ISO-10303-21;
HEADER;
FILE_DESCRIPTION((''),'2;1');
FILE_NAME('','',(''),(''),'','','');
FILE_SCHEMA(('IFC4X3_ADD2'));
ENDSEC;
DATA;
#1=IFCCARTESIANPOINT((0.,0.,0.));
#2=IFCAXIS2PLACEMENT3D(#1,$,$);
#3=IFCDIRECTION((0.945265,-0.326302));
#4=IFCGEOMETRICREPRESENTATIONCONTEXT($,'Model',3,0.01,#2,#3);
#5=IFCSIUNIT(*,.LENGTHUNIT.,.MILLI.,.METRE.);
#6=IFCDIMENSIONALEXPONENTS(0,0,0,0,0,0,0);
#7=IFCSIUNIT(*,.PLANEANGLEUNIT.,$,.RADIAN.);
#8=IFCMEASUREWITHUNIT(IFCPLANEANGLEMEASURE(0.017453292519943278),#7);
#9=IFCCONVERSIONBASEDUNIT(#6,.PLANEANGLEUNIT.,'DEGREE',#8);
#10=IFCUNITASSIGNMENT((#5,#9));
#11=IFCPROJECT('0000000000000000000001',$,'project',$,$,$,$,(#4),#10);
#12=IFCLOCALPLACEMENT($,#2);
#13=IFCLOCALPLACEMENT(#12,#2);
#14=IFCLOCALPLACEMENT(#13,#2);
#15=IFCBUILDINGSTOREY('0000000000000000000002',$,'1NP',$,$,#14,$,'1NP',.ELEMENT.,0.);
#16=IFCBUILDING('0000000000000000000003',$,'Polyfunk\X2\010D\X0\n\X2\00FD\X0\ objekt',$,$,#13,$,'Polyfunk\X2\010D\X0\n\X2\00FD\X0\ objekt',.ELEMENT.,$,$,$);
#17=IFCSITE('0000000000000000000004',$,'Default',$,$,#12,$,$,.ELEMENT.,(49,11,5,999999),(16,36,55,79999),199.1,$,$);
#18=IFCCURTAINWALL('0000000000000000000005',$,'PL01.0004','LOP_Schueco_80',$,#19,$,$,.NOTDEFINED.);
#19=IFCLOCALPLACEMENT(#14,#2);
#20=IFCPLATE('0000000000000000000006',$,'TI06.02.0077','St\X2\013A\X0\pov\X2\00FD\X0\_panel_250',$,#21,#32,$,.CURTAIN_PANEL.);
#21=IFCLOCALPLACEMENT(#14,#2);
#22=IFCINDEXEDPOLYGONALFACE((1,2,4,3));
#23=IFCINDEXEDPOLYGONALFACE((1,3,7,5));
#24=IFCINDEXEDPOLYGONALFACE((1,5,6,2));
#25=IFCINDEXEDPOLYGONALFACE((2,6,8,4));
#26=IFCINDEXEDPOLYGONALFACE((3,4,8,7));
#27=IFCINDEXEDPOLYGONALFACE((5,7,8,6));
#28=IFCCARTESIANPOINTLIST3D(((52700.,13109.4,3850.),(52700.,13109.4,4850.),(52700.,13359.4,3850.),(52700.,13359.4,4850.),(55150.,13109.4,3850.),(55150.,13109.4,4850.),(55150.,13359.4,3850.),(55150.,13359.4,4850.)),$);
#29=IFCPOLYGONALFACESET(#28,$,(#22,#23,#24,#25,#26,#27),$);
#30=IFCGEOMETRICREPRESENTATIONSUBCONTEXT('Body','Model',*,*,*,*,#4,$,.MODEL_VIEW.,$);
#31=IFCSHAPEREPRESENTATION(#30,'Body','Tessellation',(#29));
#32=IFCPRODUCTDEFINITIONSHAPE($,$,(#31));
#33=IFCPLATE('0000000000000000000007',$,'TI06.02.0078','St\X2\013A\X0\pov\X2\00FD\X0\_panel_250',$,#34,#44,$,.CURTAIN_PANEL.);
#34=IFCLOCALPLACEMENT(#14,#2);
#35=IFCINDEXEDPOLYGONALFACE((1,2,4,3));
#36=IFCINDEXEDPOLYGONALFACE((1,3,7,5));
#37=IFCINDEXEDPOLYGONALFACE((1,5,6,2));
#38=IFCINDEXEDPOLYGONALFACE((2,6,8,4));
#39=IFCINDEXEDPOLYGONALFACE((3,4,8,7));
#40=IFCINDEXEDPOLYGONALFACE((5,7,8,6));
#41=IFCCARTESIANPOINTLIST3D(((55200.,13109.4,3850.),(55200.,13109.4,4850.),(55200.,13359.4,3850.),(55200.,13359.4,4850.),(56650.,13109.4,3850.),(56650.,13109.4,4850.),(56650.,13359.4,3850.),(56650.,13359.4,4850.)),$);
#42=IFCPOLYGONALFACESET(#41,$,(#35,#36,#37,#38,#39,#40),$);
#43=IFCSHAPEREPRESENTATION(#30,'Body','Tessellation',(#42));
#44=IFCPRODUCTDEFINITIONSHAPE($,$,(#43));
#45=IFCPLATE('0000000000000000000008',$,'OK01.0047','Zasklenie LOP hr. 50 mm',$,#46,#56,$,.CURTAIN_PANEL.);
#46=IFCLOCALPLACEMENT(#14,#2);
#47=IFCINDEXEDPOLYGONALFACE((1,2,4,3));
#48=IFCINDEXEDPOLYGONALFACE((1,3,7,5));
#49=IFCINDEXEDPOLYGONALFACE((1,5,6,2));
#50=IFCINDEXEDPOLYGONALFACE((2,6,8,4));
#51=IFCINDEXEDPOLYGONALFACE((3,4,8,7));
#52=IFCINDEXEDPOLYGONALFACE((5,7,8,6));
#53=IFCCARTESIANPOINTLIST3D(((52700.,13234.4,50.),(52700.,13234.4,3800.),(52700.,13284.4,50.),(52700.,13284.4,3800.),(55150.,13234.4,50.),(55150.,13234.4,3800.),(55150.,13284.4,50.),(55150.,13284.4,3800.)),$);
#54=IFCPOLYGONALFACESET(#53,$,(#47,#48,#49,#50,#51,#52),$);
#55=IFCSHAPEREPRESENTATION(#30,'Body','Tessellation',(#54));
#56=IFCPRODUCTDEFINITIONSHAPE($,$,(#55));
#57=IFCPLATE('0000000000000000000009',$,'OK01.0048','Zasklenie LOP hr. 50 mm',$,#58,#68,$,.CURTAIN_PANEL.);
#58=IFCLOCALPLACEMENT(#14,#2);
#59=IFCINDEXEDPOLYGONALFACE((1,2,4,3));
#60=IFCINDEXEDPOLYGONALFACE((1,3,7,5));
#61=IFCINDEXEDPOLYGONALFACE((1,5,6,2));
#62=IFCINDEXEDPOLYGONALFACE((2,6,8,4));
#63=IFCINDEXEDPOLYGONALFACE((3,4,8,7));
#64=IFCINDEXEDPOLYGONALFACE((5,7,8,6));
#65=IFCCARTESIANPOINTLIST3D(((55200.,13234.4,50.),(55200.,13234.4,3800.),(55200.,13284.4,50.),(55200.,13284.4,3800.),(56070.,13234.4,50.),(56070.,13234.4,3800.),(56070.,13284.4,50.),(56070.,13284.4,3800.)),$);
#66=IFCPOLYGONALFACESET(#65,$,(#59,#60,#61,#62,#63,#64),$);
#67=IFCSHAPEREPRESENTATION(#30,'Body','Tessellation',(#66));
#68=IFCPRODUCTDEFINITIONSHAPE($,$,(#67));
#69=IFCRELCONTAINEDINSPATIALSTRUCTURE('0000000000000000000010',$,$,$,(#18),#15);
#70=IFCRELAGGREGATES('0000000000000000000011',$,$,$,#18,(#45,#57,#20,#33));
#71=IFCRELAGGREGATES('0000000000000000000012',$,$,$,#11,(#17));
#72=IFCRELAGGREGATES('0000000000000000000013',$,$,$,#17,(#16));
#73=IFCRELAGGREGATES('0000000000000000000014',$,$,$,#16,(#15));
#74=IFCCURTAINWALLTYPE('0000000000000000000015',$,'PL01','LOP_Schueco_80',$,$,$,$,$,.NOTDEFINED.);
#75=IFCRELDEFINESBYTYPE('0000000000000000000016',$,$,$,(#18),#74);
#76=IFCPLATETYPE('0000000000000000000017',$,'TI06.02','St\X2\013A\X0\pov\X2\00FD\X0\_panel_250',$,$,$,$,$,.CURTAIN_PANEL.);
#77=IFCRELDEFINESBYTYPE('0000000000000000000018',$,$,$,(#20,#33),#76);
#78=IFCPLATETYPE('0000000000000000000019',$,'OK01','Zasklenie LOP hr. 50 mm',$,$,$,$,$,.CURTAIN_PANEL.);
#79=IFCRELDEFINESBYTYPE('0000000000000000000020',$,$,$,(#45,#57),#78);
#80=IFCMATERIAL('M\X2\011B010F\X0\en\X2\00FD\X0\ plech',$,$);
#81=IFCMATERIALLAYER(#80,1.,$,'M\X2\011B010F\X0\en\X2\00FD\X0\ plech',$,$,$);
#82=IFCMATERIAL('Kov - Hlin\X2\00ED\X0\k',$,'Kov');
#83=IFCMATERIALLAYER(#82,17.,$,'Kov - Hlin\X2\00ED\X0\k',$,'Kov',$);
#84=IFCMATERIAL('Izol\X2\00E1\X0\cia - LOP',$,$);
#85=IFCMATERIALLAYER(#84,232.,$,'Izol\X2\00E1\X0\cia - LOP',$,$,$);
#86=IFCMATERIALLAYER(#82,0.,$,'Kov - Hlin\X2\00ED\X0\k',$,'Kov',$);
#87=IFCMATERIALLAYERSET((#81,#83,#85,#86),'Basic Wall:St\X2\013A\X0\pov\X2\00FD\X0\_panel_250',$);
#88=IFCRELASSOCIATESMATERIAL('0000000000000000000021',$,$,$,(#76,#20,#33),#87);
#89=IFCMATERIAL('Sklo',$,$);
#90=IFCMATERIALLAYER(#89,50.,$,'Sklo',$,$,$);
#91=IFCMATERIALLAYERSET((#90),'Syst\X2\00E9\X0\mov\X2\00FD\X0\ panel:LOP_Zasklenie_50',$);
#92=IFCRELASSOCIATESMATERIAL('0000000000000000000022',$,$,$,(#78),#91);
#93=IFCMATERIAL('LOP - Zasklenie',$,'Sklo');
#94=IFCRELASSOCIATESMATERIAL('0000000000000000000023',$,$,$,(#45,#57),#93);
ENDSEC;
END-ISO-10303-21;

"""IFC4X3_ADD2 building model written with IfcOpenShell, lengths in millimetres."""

from ifc_helpers import new_model, entity, si_unit, converted_unit, direction, frame, frame_2d, origin, origin_2d_with_axis, place, context, subcontext, project, spatial, rectangle, extrude, source, transform, mapped, material, layer, layer_set, layer_usage, type_object, type_shapes, element, aggregate, save


model = new_model("IFC4X3_ADD2")

# Units and contexts
model_context = context("Model", 3, precision=0.01, world=origin(), true_north=direction((0.945265, -0.326302)))
body_context = subcontext(model_context, "Body", "Model", "MODEL_VIEW")
ifc_project = project(units=[si_unit("LENGTHUNIT", "METRE", prefix="MILLI"), converted_unit("PLANEANGLEUNIT", "DEGREE", entity("IfcPlaneAngleMeasure", 0.017453292519943278), si_unit("PLANEANGLEUNIT", "RADIAN"), dimensions=[0, 0, 0, 0, 0, 0, 0])], contexts=[model_context])

# Site, building, storey
site_placement = place(None, origin())
site = spatial("IfcSite", under=ifc_project, at=site_placement, Name="Default", CompositionType="ELEMENT", RefLatitude=(49, 11, 5, 999999), RefLongitude=(16, 36, 55, 79999), RefElevation=199.1)
building_placement = place(site_placement, origin())
building = spatial("IfcBuilding", under=site, at=building_placement, Name="Polyfunkčný objekt", LongName="Polyfunkčný objekt", CompositionType="ELEMENT")
storey_placement = place(building_placement, origin())
storey = spatial("IfcBuildingStorey", under=building, at=storey_placement, Name="1NP", LongName="1NP", CompositionType="ELEMENT", Elevation=0.0)

# Curtain wall, plates
curtain_wall_type = type_object("IfcCurtainWallType", Name="PL01", Description="LOP_Schueco_80", PredefinedType="NOTDEFINED")
curtain_wall_placement = place(storey_placement, origin())
curtain_wall = element("IfcCurtainWall", 1, at=curtain_wall_placement, inside=storey, type_object=curtain_wall_type, Name="PL01.0004", Description="LOP_Schueco_80", PredefinedType="NOTDEFINED")
ifc_material_1 = material(Name="Měďený plech")
ifc_layer_1 = layer(ifc_material_1, 1.0, Name="Měďený plech")
ifc_material_2 = material(Name="Kov - Hliník", Category="Kov")
ifc_layer_2 = layer(ifc_material_2, 17.0, Name="Kov - Hliník", Category="Kov")
ifc_material_3 = material(Name="Izolácia - LOP")
ifc_layer_3 = layer(ifc_material_3, 232.0, Name="Izolácia - LOP")
ifc_layer_4 = layer(ifc_material_2, 0.0, Name="Kov - Hliník", Category="Kov")
ifc_layer_set_1 = layer_set([ifc_layer_1, ifc_layer_2, ifc_layer_3, ifc_layer_4], Name="Basic Wall:Stĺpový_panel_250")
ifc_layer_usage_1 = layer_usage(ifc_layer_set_1, "AXIS2", "NEGATIVE", 125.0)
plate_type_1 = type_object("IfcPlateType", Name="TI06.02", Description="Stĺpový_panel_250", PredefinedType="CURTAIN_PANEL", material=ifc_layer_set_1)
plate_1_placement = place(storey_placement, frame((52700.0, 13234.4, 3850.0)))
plate_1 = element("IfcPlate", 2, at=plate_1_placement, type_object=plate_type_1, material=ifc_layer_usage_1, Name="TI06.02.0077", Description="Stĺpový_panel_250", PredefinedType="CURTAIN_PANEL", context=body_context, shape_type="SweptSolid", body=[
    extrude(rectangle(XDim=250.0, YDim=2450.0, at=origin_2d_with_axis()), frame((1225.0, 0.0, 0.0), z_axis=(0.0, 0.0, 1.0), x_axis=(0.0, 1.0, 0.0)), (0.0, 0.0, 1.0), 1000.0),
])
ifc_layer_usage_2 = layer_usage(ifc_layer_set_1, "AXIS2", "NEGATIVE", 125.0)
plate_2_placement = place(storey_placement, frame((55200.0, 13234.4, 3850.0)))
plate_2 = element("IfcPlate", 3, at=plate_2_placement, type_object=plate_type_1, material=ifc_layer_usage_2, Name="TI06.02.0078", Description="Stĺpový_panel_250", PredefinedType="CURTAIN_PANEL", context=body_context, shape_type="SweptSolid", body=[
    extrude(rectangle(XDim=250.0, YDim=1450.0, at=origin_2d_with_axis()), frame((725.0, 0.0, 0.0), z_axis=(0.0, 0.0, 1.0), x_axis=(0.0, 1.0, 0.0)), (0.0, 0.0, 1.0), 1000.0),
])
ifc_material_4 = material(Name="LOP - Zasklenie", Category="Sklo")
ifc_material_5 = material(Name="Sklo")
ifc_layer_5 = layer(ifc_material_5, 50.0, Name="Sklo")
ifc_layer_set_2 = layer_set([ifc_layer_5], Name="Systémový panel:LOP_Zasklenie_50")
plate_type_2 = type_object("IfcPlateType", Name="OK01", Description="Zasklenie LOP hr. 50 mm", PredefinedType="CURTAIN_PANEL", material=ifc_layer_set_2)
shared_shape_1 = source(origin(), body_context, "Body", "SweptSolid", [
    extrude(rectangle(XDim=3750.0, YDim=2450.0, at=frame_2d((-141.7, 0.0), x_axis=(1.0, 0.0))), frame((0.0, 0.0, 2016.7), z_axis=(0.0, 1.0, 0.0), x_axis=(0.0, 0.0, 1.0)), (0.0, 0.0, 1.0), 50.0),
])
plate_3_placement = place(curtain_wall_placement, frame((53925.0, 13234.4, 50.0)))
plate_3 = element("IfcPlate", 4, at=plate_3_placement, type_object=plate_type_2, material=ifc_material_4, Name="OK01.0047", Description="Zasklenie LOP hr. 50 mm", PredefinedType="CURTAIN_PANEL", context=body_context, shape_type="MappedRepresentation", body=[
    mapped(shared_shape_1, transform((0.0, 0.0, 0.0), scale=1.0)),
])
shared_shape_2 = source(origin(), body_context, "Body", "SweptSolid", [
    extrude(rectangle(XDim=3750.0, YDim=870.0, at=frame_2d((-141.7, 0.0), x_axis=(1.0, 0.0))), frame((0.0, 0.0, 2016.7), z_axis=(0.0, 1.0, 0.0), x_axis=(0.0, 0.0, 1.0)), (0.0, 0.0, 1.0), 50.0),
])
type_shapes(plate_type_2, [shared_shape_1, shared_shape_2])
plate_4_placement = place(curtain_wall_placement, frame((55635.0, 13234.4, 50.0)))
plate_4 = element("IfcPlate", 5, at=plate_4_placement, type_object=plate_type_2, material=ifc_material_4, Name="OK01.0048", Description="Zasklenie LOP hr. 50 mm", PredefinedType="CURTAIN_PANEL", context=body_context, shape_type="MappedRepresentation", body=[
    mapped(shared_shape_2, transform((0.0, 0.0, 0.0), scale=1.0)),
])
aggregate(curtain_wall, [plate_3, plate_4, plate_1, plate_2])

save(model, "model.ifc")
